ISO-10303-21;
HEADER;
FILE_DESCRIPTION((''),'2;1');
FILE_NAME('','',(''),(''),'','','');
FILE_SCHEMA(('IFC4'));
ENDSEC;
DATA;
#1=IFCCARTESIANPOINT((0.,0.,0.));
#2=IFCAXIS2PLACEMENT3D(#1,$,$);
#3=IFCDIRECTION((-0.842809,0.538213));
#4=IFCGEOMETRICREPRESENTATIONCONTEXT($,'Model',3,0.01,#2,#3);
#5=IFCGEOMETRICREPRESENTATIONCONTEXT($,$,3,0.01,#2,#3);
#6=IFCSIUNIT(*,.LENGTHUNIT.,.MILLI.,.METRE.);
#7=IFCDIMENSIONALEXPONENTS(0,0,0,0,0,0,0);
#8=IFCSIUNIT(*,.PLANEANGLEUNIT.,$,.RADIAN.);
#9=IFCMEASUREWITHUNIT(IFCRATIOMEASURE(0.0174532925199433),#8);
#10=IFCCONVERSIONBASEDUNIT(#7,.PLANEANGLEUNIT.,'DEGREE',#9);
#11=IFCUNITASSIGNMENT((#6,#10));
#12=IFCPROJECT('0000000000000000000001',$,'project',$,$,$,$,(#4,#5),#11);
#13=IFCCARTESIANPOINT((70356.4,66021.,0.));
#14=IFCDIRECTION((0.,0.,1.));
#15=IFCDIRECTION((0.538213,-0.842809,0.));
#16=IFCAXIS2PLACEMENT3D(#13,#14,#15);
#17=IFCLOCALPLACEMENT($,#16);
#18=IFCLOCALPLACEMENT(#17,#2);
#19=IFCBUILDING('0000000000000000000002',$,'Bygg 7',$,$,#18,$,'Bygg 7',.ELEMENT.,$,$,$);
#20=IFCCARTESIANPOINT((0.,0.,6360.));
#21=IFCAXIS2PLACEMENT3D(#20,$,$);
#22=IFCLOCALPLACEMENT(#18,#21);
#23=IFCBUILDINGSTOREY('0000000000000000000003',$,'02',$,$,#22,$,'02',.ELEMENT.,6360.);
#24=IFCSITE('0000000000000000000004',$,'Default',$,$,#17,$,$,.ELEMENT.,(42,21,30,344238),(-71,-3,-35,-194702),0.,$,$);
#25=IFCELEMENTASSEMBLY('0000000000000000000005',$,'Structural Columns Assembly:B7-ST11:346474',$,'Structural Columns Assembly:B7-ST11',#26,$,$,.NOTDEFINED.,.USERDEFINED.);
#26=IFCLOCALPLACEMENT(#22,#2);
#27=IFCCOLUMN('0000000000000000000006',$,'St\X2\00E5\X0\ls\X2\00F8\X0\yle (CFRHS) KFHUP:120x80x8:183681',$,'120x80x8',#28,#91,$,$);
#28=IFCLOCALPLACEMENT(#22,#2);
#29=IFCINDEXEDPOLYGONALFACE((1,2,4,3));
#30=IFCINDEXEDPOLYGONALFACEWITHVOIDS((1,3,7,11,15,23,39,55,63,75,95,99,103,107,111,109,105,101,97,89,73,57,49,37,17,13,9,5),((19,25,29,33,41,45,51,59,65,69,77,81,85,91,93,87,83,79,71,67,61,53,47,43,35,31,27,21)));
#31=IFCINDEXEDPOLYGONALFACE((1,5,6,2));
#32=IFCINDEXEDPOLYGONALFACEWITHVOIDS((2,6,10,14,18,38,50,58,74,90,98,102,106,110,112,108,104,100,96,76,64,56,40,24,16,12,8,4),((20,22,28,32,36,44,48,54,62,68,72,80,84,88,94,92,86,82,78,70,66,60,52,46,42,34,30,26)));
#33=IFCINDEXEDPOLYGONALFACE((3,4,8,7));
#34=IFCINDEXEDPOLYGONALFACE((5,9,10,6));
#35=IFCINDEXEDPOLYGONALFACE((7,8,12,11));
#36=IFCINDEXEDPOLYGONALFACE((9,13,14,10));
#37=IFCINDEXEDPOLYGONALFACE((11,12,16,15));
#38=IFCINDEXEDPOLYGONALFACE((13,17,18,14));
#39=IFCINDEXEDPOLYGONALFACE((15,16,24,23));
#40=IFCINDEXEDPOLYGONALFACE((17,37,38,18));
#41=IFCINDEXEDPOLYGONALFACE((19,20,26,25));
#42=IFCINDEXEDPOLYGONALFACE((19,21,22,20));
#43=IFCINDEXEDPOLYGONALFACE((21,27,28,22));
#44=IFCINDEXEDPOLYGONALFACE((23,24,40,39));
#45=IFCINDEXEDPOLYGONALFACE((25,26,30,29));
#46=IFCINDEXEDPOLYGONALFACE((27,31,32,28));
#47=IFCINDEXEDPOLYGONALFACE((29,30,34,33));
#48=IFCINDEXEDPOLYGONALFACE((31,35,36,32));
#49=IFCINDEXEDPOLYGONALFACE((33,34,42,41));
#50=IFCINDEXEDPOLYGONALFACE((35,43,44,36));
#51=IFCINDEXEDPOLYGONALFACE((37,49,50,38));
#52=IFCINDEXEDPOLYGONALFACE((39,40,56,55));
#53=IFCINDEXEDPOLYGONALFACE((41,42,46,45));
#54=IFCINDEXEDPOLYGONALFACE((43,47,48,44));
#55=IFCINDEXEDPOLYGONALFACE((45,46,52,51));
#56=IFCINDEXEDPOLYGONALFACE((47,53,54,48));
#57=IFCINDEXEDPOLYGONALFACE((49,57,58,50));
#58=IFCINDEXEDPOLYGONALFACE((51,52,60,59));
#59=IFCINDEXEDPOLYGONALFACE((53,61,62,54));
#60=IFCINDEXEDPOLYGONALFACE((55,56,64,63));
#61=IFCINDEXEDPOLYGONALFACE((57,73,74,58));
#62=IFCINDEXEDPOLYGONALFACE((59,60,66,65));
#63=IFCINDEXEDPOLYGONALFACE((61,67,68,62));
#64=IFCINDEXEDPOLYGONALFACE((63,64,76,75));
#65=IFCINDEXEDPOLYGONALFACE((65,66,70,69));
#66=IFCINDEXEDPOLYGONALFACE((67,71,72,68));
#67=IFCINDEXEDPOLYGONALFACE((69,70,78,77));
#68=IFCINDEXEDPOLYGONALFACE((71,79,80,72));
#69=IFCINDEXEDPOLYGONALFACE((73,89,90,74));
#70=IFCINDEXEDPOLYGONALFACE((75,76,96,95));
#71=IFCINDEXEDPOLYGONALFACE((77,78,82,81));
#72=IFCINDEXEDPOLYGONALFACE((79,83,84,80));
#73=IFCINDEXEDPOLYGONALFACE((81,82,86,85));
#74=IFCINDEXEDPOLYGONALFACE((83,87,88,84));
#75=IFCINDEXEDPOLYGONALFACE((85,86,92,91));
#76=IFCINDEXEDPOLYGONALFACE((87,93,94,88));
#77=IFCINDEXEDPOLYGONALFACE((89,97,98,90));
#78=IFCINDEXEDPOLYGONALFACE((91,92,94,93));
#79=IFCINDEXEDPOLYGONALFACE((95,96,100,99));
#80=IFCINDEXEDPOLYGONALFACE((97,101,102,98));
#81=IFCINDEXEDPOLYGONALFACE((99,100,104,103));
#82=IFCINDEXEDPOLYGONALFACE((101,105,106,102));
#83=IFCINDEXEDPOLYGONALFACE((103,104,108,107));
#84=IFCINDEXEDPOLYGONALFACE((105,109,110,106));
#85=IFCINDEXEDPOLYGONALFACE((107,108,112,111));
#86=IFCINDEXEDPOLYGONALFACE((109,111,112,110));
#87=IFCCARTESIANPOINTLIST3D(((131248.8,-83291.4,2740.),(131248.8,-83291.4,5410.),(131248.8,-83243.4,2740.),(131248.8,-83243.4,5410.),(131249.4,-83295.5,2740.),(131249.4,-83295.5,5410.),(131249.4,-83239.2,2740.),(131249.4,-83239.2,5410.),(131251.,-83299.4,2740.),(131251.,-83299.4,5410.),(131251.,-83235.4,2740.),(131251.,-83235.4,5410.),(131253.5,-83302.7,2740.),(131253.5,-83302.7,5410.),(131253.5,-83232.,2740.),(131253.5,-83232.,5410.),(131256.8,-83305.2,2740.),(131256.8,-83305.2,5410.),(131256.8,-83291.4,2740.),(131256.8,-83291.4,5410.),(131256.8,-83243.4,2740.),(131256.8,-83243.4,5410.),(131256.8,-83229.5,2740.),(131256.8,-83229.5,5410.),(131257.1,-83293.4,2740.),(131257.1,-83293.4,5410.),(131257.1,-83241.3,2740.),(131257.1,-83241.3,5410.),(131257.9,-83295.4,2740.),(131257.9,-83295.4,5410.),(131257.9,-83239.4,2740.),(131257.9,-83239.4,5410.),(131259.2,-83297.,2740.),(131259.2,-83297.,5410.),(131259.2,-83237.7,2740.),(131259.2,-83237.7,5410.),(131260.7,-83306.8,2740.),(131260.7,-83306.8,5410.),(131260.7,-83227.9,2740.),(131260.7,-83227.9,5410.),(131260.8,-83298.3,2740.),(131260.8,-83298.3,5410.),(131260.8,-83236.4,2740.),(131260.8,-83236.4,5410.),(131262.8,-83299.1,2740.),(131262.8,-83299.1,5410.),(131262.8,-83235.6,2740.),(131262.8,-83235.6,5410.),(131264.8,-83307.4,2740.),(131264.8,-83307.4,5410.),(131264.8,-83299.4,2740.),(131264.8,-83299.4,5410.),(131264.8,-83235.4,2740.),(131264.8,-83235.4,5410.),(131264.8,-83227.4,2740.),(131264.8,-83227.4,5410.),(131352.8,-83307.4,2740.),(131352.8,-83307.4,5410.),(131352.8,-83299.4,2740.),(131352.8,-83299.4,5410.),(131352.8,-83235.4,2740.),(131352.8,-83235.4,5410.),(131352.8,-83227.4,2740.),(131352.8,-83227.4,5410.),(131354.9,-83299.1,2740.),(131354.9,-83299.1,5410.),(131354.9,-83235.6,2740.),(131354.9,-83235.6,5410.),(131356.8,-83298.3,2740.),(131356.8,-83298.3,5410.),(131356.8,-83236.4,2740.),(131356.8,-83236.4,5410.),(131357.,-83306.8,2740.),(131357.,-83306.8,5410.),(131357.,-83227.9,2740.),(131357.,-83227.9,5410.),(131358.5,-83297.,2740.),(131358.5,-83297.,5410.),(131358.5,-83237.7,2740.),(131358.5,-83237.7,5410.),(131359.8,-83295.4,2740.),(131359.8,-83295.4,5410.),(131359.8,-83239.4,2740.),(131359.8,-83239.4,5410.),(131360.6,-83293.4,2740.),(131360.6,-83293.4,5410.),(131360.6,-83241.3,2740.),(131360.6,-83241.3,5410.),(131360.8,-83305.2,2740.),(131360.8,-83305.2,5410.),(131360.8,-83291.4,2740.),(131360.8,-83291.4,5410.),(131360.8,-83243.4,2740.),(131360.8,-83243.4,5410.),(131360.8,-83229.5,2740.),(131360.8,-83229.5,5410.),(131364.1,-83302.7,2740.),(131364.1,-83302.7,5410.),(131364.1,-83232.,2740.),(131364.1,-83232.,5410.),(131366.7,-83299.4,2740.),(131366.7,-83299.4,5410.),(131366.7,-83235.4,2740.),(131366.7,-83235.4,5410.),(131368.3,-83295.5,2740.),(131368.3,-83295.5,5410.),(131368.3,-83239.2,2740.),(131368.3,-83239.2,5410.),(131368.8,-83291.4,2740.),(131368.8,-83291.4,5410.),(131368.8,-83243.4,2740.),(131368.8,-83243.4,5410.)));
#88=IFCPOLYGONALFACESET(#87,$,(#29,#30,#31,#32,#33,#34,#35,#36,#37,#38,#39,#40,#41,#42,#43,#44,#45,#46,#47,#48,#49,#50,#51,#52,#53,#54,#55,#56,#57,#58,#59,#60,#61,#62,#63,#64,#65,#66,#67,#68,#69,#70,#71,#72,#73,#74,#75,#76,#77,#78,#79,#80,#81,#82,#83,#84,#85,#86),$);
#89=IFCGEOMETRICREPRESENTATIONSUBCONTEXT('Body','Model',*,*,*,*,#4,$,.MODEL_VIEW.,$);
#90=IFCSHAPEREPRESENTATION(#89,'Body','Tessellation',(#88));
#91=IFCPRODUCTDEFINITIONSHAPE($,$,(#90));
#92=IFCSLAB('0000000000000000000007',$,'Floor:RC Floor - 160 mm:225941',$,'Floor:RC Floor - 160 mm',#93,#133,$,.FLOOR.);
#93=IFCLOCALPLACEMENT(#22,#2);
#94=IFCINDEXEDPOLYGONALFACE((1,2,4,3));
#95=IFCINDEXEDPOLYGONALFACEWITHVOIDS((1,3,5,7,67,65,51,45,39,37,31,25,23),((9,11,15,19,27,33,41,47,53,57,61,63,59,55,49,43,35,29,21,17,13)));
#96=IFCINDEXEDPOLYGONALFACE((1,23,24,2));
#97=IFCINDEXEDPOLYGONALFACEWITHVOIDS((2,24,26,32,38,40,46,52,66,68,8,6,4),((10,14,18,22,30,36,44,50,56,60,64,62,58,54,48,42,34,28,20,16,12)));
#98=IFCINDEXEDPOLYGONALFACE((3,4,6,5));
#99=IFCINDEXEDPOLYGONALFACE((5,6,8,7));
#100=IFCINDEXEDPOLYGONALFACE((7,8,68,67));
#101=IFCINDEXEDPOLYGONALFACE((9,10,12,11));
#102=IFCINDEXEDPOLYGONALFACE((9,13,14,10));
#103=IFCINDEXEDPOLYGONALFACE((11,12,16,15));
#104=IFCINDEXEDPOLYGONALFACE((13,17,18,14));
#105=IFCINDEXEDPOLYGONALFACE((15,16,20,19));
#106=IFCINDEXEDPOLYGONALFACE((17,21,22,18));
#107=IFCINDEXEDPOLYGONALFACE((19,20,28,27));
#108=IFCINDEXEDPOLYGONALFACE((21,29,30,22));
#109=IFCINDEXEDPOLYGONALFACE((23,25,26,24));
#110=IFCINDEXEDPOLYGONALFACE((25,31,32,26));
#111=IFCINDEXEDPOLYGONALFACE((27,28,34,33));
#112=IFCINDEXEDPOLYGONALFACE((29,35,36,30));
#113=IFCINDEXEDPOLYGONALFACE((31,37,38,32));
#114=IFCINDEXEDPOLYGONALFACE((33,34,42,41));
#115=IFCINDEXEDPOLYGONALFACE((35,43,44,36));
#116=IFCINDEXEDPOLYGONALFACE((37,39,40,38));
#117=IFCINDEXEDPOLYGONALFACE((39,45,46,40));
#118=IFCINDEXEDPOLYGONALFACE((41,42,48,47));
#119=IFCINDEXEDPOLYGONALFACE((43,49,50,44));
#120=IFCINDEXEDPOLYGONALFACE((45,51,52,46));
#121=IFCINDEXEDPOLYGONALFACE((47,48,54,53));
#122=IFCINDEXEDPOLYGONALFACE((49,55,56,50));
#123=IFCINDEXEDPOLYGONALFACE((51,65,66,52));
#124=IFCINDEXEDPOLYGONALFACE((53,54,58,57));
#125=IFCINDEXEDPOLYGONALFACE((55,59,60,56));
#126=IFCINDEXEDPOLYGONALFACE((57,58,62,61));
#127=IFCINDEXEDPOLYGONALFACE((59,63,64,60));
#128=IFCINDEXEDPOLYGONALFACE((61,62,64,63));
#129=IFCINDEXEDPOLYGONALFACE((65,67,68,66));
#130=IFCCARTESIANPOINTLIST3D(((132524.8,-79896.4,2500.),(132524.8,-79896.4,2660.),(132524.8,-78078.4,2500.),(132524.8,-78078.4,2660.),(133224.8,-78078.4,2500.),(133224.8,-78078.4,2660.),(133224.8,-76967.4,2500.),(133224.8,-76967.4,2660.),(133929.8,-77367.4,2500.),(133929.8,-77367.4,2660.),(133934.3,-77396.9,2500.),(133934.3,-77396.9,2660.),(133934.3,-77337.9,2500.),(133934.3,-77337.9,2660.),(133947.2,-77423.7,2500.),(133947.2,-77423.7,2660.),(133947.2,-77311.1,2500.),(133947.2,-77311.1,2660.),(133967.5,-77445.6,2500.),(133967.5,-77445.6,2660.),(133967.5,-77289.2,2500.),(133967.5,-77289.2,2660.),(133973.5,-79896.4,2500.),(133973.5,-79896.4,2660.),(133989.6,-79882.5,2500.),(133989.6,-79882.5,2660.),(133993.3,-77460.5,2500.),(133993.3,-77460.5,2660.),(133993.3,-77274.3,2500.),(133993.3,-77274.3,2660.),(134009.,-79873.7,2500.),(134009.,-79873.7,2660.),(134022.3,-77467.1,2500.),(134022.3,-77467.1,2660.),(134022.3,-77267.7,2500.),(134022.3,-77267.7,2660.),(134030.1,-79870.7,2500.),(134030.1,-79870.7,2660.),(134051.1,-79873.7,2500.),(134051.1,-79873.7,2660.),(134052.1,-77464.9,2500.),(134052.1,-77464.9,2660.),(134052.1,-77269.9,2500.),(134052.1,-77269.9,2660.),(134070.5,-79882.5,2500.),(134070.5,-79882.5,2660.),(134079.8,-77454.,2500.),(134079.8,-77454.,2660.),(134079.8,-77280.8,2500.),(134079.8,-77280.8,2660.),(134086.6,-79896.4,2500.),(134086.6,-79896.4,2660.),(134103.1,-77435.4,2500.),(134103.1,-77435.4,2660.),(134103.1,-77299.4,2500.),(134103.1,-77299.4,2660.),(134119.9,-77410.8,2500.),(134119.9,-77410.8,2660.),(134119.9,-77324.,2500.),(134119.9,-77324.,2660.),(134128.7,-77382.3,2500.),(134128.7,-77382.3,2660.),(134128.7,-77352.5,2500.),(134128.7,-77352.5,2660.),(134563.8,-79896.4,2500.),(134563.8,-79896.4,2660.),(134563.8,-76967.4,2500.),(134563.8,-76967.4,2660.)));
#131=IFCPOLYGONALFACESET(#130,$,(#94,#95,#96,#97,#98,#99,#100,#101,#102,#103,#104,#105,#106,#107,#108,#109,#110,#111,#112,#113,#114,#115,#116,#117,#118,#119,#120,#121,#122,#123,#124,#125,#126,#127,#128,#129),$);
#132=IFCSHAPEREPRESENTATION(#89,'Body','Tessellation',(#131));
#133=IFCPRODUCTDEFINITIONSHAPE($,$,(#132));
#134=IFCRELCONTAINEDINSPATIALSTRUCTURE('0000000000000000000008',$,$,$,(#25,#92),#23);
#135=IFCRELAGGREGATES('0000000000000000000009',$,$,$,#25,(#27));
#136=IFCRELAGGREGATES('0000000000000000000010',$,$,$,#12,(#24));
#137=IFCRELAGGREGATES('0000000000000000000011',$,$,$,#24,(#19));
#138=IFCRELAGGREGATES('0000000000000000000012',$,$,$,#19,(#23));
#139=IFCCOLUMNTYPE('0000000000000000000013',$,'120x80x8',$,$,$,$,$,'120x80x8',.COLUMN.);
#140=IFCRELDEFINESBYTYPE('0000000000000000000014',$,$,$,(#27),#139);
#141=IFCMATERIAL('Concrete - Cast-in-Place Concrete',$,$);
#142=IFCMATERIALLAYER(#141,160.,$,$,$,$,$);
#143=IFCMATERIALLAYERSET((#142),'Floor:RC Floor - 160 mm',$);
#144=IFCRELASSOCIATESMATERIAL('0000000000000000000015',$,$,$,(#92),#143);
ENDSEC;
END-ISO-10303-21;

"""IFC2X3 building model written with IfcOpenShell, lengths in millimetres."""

from ifc_helpers import new_model, entity, si_unit, converted_unit, direction, frame, frame_2d, origin, place, context, subcontext, project, spatial, polyline, circle_curve, parameter, trimmed, segment, composite_curve, circle, outline, extrude, source, transform, mapped, material, layer, layer_set, layer_usage, type_object, type_shapes, element, aggregate, save


model = new_model("IFC2X3")

# Units and contexts
model_context = context("Model", 3, precision=0.01, world=origin(), true_north=direction((-0.842809, 0.538213)))
context_of_model = context(None, 3, precision=0.01, world=origin(), true_north=direction((-0.842809, 0.538213)))
body_context = subcontext(model_context, "Body", "Model", "MODEL_VIEW")
ifc_project = project(units=[si_unit("LENGTHUNIT", "METRE", prefix="MILLI"), converted_unit("PLANEANGLEUNIT", "DEGREE", entity("IfcRatioMeasure", 0.0174532925199433), si_unit("PLANEANGLEUNIT", "RADIAN"), dimensions=[0, 0, 0, 0, 0, 0, 0])], contexts=[model_context, context_of_model])

# Site, building, storey
site_placement = place(None, frame((70356.4, 66021.0, 0.0), z_axis=(0.0, 0.0, 1.0), x_axis=(0.538213, -0.842809, 0.0)))
site = spatial("IfcSite", under=ifc_project, at=site_placement, Name="Default", CompositionType="ELEMENT", RefLatitude=(42, 21, 30, 344238), RefLongitude=(-71, -3, -35, -194702), RefElevation=0.0)
building_placement = place(site_placement, origin())
building = spatial("IfcBuilding", under=site, at=building_placement, Name="Bygg 7", LongName="Bygg 7", CompositionType="ELEMENT")
storey_placement = place(building_placement, frame((0.0, 0.0, 6360.0)))
storey = spatial("IfcBuildingStorey", under=building, at=storey_placement, Name="02", LongName="02", CompositionType="ELEMENT", Elevation=6360.0)

# Element assembly, column
assembly_1_placement = place(storey_placement, origin())
assembly_1 = element("IfcElementAssembly", 1, at=assembly_1_placement, inside=storey, Name="Structural Columns Assembly:B7-ST11:346474", ObjectType="Structural Columns Assembly:B7-ST11", AssemblyPlace="NOTDEFINED", PredefinedType="USERDEFINED")
column_type_1 = type_object("IfcColumnType", Name="120x80x8", ElementType="120x80x8", PredefinedType="COLUMN")
shared_shape_1 = source(origin(), body_context, "Body", "SweptSolid", [
    extrude(outline(composite_curve([segment(trimmed(circle_curve(frame_2d((-24.0, 44.0), x_axis=(1.0, 0.0)), 16.0), [parameter(90.0)], [parameter(180.0)], True, "PARAMETER"), True, "CONTINUOUS"), segment(polyline([(-40.0, 44.0), (-40.0, -44.0)]), True, "CONTINUOUS"), segment(trimmed(circle_curve(frame_2d((-24.0, -44.0), x_axis=(1.0, 0.0)), 16.0), [parameter(180.0)], [parameter(270.0)], True, "PARAMETER"), True, "CONTINUOUS"), segment(polyline([(-24.0, -60.0), (24.0, -60.0)]), True, "CONTINUOUS"), segment(trimmed(circle_curve(frame_2d((24.0, -44.0), x_axis=(1.0, 0.0)), 16.0), [parameter(270.0)], [parameter(0.0)], True, "PARAMETER"), True, "CONTINUOUS"), segment(polyline([(40.0, -44.0), (40.0, 44.0)]), True, "CONTINUOUS"), segment(trimmed(circle_curve(frame_2d((24.0, 44.0), x_axis=(1.0, 0.0)), 16.0), [parameter(0.0)], [parameter(90.0)], True, "PARAMETER"), True, "CONTINUOUS"), segment(polyline([(24.0, 60.0), (-24.0, 60.0)]), True, "CONTINUOUS")], self_intersect=False), holes=[composite_curve([segment(polyline([(-24.0, 52.0), (24.0, 52.0)]), True, "CONTINUOUS"), segment(trimmed(circle_curve(frame_2d((24.0, 44.0), x_axis=(1.0, 0.0)), 8.0), [parameter(360.0)], [parameter(90.0)], True, "PARAMETER"), False, "CONTINUOUS"), segment(polyline([(32.0, 44.0), (32.0, -44.0)]), True, "CONTINUOUS"), segment(trimmed(circle_curve(frame_2d((24.0, -44.0), x_axis=(1.0, 0.0)), 8.0), [parameter(270.0)], [parameter(360.0)], True, "PARAMETER"), False, "CONTINUOUS"), segment(polyline([(24.0, -52.0), (-24.0, -52.0)]), True, "CONTINUOUS"), segment(trimmed(circle_curve(frame_2d((-24.0, -44.0), x_axis=(1.0, 0.0)), 8.0), [parameter(180.0)], [parameter(270.0)], True, "PARAMETER"), False, "CONTINUOUS"), segment(polyline([(-32.0, -44.0), (-32.0, 44.0)]), True, "CONTINUOUS"), segment(trimmed(circle_curve(frame_2d((-24.0, 44.0), x_axis=(1.0, 0.0)), 8.0), [parameter(90.0)], [parameter(180.0)], True, "PARAMETER"), False, "CONTINUOUS")], self_intersect=False)]), frame((61.6, 41.6, 0.0), z_axis=(0.0, 0.0, 1.0), x_axis=(0.0, -1.0, 0.0)), (0.0, 0.0, 1.0), 2670.0),
])
type_shapes(column_type_1, [shared_shape_1])
column_1_placement = place(assembly_1_placement, frame((131247.2, -83309.0, 2740.0)))
column_1 = element("IfcColumn", 2, at=column_1_placement, type_object=column_type_1, Name="Stålsøyle (CFRHS) KFHUP:120x80x8:183681", ObjectType="120x80x8", context=body_context, shape_type="MappedRepresentation", body=[
    mapped(shared_shape_1, transform((0.0, 0.0, 0.0), scale=1.0)),
])
aggregate(assembly_1, [column_1])

# Slab, openings
ifc_material_1 = material(Name="Concrete - Cast-in-Place Concrete")
ifc_layer_1 = layer(ifc_material_1, 160.0)
ifc_layer_set_1 = layer_set([ifc_layer_1], Name="Floor:RC Floor - 160 mm")
ifc_layer_usage_1 = layer_usage(ifc_layer_set_1, "AXIS3", "POSITIVE", 0.0)
slab_1_placement = place(storey_placement, frame((132524.8, -79896.4, 2500.0)))
slab_1 = element("IfcSlab", 3, at=slab_1_placement, inside=storey, material=ifc_layer_usage_1, Name="Floor:RC Floor - 160 mm:225941", ObjectType="Floor:RC Floor - 160 mm", PredefinedType="FLOOR", context=body_context, shape_type="SweptSolid", body=[
    extrude(outline(polyline([(1019.5, 353.5), (319.5, 353.5), (319.5, 1464.5), (-1019.5, 1464.5), (-1019.5, -1464.5), (1019.5, -1464.5), (1019.5, 353.5)])), frame((1019.5, 1464.5, 160.0), z_axis=(0.0, 0.0, -1.0), x_axis=(-1.0, 0.0, 0.0)), (0.0, 0.0, 1.0), 160.0),
])
opening_1_placement = place(storey_placement, frame((132524.8, -79896.4, 2500.0)))
element("IfcOpeningElement", 4, at=opening_1_placement, cuts=slab_1, ObjectType="Opening", context=body_context, shape_type="SweptSolid", body=[
    extrude(circle(Radius=75.0, at=frame_2d((-485.7, -1513.8), x_axis=(1.0, 0.0))), frame((1019.5, 1464.5, 160.0), z_axis=(0.0, 0.0, -1.0), x_axis=(-1.0, 0.0, 0.0)), (0.0, 0.0, 1.0), 160.0),
])
opening_2_placement = place(storey_placement, frame((132524.8, -79896.4, 2500.0)))
element("IfcOpeningElement", 5, at=opening_2_placement, cuts=slab_1, ObjectType="Opening", context=body_context, shape_type="SweptSolid", body=[
    extrude(circle(Radius=100.0, at=frame_2d((-485.5, 1064.5), x_axis=(1.0, 0.0))), frame((1019.5, 1464.5, 160.0), z_axis=(0.0, 0.0, -1.0), x_axis=(-1.0, 0.0, 0.0)), (0.0, 0.0, 1.0), 160.0),
])

save(model, "model.ifc")
